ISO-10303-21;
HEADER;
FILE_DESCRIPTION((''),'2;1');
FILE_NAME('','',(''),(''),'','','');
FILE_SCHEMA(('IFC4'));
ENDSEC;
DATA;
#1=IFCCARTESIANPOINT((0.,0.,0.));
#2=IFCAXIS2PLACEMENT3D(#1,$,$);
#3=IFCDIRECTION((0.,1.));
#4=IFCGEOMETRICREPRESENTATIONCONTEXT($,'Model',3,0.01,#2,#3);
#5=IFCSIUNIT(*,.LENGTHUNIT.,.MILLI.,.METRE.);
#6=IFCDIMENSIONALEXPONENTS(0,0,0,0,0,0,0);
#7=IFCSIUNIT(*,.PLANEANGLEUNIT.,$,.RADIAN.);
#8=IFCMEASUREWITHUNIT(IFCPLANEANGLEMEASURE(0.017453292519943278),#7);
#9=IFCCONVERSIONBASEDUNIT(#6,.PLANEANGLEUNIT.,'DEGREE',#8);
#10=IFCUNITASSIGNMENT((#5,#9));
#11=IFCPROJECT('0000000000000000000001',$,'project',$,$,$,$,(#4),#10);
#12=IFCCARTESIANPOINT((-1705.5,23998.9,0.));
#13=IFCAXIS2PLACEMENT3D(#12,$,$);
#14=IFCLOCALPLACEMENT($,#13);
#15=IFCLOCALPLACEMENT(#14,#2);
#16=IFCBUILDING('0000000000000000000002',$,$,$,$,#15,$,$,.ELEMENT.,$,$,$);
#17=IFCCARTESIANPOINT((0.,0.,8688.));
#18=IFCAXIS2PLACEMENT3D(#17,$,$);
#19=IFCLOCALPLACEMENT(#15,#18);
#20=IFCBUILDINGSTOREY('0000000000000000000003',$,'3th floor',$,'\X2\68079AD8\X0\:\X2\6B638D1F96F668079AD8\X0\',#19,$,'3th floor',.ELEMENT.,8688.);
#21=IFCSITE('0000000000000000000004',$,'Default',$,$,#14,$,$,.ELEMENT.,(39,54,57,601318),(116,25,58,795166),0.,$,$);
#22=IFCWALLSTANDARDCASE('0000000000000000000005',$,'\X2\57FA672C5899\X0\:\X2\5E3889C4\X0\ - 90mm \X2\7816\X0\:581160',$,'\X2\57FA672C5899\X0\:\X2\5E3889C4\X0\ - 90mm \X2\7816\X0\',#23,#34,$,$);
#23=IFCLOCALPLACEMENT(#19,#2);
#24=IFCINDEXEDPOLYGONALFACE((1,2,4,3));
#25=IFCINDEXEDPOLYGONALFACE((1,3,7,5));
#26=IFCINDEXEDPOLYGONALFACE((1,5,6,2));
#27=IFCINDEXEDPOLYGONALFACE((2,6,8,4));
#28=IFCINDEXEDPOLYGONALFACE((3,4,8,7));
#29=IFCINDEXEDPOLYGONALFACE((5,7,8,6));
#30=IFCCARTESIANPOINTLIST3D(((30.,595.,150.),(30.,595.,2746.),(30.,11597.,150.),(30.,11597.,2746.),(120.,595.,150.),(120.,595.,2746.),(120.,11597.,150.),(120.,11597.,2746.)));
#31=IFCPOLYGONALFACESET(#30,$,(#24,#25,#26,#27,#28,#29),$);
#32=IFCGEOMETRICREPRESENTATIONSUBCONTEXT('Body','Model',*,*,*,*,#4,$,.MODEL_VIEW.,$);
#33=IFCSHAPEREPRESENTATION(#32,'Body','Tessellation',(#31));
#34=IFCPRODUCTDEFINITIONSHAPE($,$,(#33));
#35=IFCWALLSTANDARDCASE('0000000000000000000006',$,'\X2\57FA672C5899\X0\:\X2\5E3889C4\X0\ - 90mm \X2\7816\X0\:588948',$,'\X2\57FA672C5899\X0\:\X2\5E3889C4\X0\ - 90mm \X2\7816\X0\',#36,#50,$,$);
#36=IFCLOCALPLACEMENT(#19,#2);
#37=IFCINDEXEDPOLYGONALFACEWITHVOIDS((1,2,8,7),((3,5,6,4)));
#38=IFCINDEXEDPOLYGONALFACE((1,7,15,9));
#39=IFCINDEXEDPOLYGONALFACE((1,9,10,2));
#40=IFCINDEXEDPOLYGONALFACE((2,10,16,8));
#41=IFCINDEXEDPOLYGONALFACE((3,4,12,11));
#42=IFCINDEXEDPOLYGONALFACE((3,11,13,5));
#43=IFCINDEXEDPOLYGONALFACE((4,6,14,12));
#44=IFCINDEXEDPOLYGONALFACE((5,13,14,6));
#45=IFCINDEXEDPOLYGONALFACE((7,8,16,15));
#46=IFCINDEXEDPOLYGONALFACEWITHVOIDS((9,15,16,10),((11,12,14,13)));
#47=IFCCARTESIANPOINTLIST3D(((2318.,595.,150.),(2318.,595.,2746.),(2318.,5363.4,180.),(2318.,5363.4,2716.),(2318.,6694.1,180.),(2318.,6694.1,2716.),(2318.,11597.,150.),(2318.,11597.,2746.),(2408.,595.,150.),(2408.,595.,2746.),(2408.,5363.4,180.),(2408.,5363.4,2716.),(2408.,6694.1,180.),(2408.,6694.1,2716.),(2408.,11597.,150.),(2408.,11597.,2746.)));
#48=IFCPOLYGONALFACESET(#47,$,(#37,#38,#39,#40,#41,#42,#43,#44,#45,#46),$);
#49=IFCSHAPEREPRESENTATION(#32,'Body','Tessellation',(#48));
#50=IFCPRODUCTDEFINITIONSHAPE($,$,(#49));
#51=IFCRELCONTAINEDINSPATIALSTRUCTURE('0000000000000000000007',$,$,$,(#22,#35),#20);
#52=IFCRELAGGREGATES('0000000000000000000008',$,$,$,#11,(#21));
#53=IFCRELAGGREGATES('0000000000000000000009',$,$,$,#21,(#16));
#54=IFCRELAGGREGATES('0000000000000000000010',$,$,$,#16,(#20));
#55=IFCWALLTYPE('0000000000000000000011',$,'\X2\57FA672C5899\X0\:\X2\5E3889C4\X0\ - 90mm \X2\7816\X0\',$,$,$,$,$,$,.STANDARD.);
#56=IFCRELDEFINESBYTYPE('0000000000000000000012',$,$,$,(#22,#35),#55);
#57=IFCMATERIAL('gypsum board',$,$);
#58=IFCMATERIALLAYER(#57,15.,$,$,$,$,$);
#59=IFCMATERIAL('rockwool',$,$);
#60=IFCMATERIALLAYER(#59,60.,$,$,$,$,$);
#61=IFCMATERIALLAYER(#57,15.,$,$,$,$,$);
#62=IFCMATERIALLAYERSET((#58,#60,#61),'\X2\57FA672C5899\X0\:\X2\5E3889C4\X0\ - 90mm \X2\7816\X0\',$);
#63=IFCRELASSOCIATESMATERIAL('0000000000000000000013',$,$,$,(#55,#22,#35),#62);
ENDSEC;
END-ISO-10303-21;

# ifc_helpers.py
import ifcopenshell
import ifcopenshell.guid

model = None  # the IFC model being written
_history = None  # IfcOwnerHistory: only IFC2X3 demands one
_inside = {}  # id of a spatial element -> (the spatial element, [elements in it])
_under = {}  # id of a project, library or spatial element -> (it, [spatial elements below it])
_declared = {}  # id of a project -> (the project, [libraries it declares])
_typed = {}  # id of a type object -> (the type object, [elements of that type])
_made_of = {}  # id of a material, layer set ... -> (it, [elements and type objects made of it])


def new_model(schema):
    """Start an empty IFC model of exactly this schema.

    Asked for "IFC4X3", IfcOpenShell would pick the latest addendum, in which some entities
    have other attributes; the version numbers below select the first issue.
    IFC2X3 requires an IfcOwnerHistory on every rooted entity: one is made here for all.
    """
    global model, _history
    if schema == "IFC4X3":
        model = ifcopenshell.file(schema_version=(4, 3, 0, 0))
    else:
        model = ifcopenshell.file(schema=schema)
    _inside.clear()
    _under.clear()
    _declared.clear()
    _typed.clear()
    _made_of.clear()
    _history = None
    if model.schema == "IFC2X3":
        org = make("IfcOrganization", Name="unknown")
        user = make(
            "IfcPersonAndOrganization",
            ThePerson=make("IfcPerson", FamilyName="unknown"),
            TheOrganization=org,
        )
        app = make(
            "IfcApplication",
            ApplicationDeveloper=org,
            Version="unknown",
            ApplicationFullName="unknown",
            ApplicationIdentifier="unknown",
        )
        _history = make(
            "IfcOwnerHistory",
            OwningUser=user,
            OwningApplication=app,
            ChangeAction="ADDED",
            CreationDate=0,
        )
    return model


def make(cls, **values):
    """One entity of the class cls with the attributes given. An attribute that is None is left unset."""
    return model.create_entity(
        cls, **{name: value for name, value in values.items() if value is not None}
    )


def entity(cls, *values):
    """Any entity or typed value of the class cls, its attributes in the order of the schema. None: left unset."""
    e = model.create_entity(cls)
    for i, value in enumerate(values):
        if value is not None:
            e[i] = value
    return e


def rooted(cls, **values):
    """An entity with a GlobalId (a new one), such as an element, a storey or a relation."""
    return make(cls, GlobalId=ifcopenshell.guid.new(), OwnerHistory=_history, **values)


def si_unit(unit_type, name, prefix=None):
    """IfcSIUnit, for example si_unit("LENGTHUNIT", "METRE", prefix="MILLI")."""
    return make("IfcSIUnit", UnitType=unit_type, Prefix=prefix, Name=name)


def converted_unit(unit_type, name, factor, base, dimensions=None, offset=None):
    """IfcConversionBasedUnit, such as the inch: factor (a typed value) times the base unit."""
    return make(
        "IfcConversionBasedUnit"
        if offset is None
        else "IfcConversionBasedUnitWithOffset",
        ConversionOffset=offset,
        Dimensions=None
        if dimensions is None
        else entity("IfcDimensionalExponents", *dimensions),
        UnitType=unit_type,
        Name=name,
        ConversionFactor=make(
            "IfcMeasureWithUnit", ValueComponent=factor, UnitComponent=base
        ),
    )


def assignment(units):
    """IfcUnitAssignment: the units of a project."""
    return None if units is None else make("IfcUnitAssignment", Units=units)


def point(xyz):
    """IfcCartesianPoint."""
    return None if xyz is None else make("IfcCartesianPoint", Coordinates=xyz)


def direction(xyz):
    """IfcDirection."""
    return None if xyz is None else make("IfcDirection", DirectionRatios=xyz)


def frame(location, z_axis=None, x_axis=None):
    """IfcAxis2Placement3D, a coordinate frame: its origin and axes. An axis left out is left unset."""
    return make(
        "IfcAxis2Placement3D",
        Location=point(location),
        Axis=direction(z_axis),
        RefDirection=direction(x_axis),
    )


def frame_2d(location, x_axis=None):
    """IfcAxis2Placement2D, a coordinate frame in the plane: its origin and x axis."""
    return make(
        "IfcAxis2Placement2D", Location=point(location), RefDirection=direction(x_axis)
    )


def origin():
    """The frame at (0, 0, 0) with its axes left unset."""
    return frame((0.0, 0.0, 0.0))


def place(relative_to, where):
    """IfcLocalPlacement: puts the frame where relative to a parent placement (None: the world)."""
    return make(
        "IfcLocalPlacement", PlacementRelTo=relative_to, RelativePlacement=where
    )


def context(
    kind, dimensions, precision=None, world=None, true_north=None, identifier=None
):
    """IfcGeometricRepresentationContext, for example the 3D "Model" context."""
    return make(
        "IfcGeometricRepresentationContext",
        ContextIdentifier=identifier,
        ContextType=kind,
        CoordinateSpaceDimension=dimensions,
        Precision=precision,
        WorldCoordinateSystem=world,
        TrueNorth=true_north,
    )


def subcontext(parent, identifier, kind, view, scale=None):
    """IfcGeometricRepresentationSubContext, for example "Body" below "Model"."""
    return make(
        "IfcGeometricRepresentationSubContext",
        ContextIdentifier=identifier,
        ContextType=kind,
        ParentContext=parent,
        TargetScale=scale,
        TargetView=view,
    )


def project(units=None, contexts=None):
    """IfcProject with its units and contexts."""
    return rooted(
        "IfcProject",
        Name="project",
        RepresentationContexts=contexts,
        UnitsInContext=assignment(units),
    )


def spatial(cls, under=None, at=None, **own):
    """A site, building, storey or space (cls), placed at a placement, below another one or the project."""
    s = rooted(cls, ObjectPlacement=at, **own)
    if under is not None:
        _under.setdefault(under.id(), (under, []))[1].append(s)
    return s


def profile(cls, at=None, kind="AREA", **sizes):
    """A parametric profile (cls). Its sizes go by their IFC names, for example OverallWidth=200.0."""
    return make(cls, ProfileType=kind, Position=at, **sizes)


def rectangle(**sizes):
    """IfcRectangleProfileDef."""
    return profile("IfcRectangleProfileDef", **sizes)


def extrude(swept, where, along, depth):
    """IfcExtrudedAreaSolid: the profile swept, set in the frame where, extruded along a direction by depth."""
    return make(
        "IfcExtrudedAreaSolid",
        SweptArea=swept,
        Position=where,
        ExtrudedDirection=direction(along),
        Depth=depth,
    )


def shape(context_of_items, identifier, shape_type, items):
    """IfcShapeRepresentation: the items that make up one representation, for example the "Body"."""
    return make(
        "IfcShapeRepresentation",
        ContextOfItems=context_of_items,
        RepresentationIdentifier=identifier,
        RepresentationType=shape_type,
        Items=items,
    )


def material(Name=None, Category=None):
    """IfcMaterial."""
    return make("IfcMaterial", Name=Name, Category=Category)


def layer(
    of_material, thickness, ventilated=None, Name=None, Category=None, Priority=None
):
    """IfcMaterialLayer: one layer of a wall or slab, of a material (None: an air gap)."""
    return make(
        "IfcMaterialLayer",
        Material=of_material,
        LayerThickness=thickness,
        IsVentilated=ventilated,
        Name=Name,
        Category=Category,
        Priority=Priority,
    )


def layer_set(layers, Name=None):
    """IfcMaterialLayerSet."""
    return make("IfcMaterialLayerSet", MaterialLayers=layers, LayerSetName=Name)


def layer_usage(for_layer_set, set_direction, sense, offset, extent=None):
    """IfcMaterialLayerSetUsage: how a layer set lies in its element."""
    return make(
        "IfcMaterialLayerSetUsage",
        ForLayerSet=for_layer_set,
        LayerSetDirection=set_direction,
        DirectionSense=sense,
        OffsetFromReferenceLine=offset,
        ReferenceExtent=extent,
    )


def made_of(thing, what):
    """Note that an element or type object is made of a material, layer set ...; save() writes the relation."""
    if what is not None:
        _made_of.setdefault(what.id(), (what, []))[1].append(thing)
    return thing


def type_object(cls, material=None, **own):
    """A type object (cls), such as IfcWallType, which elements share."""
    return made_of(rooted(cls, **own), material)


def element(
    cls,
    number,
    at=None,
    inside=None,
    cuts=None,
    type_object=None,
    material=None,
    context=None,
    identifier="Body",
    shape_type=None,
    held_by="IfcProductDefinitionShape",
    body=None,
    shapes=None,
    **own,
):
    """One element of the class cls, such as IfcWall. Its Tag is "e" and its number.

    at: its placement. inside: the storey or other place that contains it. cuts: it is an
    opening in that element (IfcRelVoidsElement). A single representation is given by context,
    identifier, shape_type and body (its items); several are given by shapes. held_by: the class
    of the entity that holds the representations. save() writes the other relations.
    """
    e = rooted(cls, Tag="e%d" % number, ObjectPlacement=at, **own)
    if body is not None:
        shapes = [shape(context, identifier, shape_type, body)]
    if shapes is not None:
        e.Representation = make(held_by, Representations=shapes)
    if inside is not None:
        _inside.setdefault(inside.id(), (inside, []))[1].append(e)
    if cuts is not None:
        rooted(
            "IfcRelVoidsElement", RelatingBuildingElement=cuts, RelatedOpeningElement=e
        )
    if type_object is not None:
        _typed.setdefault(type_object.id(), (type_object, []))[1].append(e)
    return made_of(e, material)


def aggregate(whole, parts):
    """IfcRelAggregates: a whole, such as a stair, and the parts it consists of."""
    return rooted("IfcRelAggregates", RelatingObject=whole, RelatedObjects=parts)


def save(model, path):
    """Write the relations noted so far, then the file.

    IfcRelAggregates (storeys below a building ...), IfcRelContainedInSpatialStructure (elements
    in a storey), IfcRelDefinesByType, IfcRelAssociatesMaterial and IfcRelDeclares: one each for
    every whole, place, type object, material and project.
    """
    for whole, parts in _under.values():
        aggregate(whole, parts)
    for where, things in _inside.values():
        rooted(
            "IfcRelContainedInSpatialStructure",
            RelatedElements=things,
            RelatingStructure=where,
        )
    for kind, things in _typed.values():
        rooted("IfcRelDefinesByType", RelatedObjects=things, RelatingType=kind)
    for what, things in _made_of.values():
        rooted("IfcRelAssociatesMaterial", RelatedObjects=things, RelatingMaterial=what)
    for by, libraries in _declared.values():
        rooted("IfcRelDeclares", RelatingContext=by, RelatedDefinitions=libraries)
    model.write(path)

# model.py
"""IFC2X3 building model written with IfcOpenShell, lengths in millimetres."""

from ifc_helpers import new_model, entity, si_unit, converted_unit, direction, frame, frame_2d, origin, place, context, subcontext, project, spatial, rectangle, extrude, material, layer, layer_set, layer_usage, type_object, element, save


model = new_model("IFC2X3")

# Units and contexts
model_context = context("Model", 3, precision=0.01, world=origin(), true_north=direction((0.0, 1.0)))
body_context = subcontext(model_context, "Body", "Model", "MODEL_VIEW")
ifc_project = project(units=[si_unit("LENGTHUNIT", "METRE", prefix="MILLI"), converted_unit("PLANEANGLEUNIT", "DEGREE", entity("IfcPlaneAngleMeasure", 0.017453292519943278), si_unit("PLANEANGLEUNIT", "RADIAN"), dimensions=[0, 0, 0, 0, 0, 0, 0])], contexts=[model_context])

# Site, building, storey
site_placement = place(None, frame((-1705.5, 23998.9, 0.0)))
site = spatial("IfcSite", under=ifc_project, at=site_placement, Name="Default", CompositionType="ELEMENT", RefLatitude=(39, 54, 57, 601318), RefLongitude=(116, 25, 58, 795166), RefElevation=0.0)
building_placement = place(site_placement, origin())
building = spatial("IfcBuilding", under=site, at=building_placement, CompositionType="ELEMENT")
storey_placement = place(building_placement, frame((0.0, 0.0, 8688.0)))
storey = spatial("IfcBuildingStorey", under=building, at=storey_placement, Name="3th floor", ObjectType="标高:正负零标高", LongName="3th floor", CompositionType="ELEMENT", Elevation=8688.0)

# Wall
ifc_material_1 = material(Name="gypsum board")
ifc_layer_1 = layer(ifc_material_1, 15.0)
ifc_material_2 = material(Name="rockwool")
ifc_layer_2 = layer(ifc_material_2, 60.0)
ifc_layer_3 = layer(ifc_material_1, 15.0)
ifc_layer_set = layer_set([ifc_layer_1, ifc_layer_2, ifc_layer_3], Name="基本墙:常规 - 90mm 砖")
ifc_layer_usage_1 = layer_usage(ifc_layer_set, "AXIS2", "NEGATIVE", 45.0)
wall_type = type_object("IfcWallType", Name="基本墙:常规 - 90mm 砖", PredefinedType="STANDARD", material=ifc_layer_set)
wall_1_placement = place(storey_placement, frame((75.0, 11597.0, 150.0), z_axis=(0.0, 0.0, 1.0), x_axis=(0.0, -1.0, 0.0)))
element("IfcWallStandardCase", 1, at=wall_1_placement, inside=storey, type_object=wall_type, material=ifc_layer_usage_1, Name="基本墙:常规 - 90mm 砖:581160", ObjectType="基本墙:常规 - 90mm 砖", context=body_context, shape_type="SweptSolid", body=[
    extrude(rectangle(XDim=11002.0, YDim=90.0, at=frame_2d((5501.0, 0.0), x_axis=(-1.0, 0.0))), origin(), (0.0, 0.0, 1.0), 2596.0),
])

# Wall, opening
ifc_layer_usage_2 = layer_usage(ifc_layer_set, "AXIS2", "NEGATIVE", 45.0)
wall_2_placement = place(storey_placement, frame((2363.0, 11597.0, 150.0), z_axis=(0.0, 0.0, 1.0), x_axis=(0.0, -1.0, 0.0)))
wall_2 = element("IfcWallStandardCase", 2, at=wall_2_placement, inside=storey, type_object=wall_type, material=ifc_layer_usage_2, Name="基本墙:常规 - 90mm 砖:588948", ObjectType="基本墙:常规 - 90mm 砖", context=body_context, shape_type="SweptSolid", body=[
    extrude(rectangle(XDim=11002.0, YDim=90.0, at=frame_2d((5501.0, 0.0), x_axis=(-1.0, 0.0))), origin(), (0.0, 0.0, 1.0), 2596.0),
])
opening_1_placement = place(wall_2_placement, origin())
element("IfcOpeningElement", 3, at=opening_1_placement, cuts=wall_2, ObjectType="Opening", context=body_context, shape_type="SweptSolid", body=[
    extrude(rectangle(XDim=2536.0, YDim=1330.8, at=frame_2d((0.0, 0.0), x_axis=(0.0, 1.0))), frame((5568.2, 45.0, 1298.0), z_axis=(0.0, -1.0, 0.0), x_axis=(-1.0, 0.0, 0.0)), (0.0, 0.0, 1.0), 90.0),
])

save(model, "model.ifc")
